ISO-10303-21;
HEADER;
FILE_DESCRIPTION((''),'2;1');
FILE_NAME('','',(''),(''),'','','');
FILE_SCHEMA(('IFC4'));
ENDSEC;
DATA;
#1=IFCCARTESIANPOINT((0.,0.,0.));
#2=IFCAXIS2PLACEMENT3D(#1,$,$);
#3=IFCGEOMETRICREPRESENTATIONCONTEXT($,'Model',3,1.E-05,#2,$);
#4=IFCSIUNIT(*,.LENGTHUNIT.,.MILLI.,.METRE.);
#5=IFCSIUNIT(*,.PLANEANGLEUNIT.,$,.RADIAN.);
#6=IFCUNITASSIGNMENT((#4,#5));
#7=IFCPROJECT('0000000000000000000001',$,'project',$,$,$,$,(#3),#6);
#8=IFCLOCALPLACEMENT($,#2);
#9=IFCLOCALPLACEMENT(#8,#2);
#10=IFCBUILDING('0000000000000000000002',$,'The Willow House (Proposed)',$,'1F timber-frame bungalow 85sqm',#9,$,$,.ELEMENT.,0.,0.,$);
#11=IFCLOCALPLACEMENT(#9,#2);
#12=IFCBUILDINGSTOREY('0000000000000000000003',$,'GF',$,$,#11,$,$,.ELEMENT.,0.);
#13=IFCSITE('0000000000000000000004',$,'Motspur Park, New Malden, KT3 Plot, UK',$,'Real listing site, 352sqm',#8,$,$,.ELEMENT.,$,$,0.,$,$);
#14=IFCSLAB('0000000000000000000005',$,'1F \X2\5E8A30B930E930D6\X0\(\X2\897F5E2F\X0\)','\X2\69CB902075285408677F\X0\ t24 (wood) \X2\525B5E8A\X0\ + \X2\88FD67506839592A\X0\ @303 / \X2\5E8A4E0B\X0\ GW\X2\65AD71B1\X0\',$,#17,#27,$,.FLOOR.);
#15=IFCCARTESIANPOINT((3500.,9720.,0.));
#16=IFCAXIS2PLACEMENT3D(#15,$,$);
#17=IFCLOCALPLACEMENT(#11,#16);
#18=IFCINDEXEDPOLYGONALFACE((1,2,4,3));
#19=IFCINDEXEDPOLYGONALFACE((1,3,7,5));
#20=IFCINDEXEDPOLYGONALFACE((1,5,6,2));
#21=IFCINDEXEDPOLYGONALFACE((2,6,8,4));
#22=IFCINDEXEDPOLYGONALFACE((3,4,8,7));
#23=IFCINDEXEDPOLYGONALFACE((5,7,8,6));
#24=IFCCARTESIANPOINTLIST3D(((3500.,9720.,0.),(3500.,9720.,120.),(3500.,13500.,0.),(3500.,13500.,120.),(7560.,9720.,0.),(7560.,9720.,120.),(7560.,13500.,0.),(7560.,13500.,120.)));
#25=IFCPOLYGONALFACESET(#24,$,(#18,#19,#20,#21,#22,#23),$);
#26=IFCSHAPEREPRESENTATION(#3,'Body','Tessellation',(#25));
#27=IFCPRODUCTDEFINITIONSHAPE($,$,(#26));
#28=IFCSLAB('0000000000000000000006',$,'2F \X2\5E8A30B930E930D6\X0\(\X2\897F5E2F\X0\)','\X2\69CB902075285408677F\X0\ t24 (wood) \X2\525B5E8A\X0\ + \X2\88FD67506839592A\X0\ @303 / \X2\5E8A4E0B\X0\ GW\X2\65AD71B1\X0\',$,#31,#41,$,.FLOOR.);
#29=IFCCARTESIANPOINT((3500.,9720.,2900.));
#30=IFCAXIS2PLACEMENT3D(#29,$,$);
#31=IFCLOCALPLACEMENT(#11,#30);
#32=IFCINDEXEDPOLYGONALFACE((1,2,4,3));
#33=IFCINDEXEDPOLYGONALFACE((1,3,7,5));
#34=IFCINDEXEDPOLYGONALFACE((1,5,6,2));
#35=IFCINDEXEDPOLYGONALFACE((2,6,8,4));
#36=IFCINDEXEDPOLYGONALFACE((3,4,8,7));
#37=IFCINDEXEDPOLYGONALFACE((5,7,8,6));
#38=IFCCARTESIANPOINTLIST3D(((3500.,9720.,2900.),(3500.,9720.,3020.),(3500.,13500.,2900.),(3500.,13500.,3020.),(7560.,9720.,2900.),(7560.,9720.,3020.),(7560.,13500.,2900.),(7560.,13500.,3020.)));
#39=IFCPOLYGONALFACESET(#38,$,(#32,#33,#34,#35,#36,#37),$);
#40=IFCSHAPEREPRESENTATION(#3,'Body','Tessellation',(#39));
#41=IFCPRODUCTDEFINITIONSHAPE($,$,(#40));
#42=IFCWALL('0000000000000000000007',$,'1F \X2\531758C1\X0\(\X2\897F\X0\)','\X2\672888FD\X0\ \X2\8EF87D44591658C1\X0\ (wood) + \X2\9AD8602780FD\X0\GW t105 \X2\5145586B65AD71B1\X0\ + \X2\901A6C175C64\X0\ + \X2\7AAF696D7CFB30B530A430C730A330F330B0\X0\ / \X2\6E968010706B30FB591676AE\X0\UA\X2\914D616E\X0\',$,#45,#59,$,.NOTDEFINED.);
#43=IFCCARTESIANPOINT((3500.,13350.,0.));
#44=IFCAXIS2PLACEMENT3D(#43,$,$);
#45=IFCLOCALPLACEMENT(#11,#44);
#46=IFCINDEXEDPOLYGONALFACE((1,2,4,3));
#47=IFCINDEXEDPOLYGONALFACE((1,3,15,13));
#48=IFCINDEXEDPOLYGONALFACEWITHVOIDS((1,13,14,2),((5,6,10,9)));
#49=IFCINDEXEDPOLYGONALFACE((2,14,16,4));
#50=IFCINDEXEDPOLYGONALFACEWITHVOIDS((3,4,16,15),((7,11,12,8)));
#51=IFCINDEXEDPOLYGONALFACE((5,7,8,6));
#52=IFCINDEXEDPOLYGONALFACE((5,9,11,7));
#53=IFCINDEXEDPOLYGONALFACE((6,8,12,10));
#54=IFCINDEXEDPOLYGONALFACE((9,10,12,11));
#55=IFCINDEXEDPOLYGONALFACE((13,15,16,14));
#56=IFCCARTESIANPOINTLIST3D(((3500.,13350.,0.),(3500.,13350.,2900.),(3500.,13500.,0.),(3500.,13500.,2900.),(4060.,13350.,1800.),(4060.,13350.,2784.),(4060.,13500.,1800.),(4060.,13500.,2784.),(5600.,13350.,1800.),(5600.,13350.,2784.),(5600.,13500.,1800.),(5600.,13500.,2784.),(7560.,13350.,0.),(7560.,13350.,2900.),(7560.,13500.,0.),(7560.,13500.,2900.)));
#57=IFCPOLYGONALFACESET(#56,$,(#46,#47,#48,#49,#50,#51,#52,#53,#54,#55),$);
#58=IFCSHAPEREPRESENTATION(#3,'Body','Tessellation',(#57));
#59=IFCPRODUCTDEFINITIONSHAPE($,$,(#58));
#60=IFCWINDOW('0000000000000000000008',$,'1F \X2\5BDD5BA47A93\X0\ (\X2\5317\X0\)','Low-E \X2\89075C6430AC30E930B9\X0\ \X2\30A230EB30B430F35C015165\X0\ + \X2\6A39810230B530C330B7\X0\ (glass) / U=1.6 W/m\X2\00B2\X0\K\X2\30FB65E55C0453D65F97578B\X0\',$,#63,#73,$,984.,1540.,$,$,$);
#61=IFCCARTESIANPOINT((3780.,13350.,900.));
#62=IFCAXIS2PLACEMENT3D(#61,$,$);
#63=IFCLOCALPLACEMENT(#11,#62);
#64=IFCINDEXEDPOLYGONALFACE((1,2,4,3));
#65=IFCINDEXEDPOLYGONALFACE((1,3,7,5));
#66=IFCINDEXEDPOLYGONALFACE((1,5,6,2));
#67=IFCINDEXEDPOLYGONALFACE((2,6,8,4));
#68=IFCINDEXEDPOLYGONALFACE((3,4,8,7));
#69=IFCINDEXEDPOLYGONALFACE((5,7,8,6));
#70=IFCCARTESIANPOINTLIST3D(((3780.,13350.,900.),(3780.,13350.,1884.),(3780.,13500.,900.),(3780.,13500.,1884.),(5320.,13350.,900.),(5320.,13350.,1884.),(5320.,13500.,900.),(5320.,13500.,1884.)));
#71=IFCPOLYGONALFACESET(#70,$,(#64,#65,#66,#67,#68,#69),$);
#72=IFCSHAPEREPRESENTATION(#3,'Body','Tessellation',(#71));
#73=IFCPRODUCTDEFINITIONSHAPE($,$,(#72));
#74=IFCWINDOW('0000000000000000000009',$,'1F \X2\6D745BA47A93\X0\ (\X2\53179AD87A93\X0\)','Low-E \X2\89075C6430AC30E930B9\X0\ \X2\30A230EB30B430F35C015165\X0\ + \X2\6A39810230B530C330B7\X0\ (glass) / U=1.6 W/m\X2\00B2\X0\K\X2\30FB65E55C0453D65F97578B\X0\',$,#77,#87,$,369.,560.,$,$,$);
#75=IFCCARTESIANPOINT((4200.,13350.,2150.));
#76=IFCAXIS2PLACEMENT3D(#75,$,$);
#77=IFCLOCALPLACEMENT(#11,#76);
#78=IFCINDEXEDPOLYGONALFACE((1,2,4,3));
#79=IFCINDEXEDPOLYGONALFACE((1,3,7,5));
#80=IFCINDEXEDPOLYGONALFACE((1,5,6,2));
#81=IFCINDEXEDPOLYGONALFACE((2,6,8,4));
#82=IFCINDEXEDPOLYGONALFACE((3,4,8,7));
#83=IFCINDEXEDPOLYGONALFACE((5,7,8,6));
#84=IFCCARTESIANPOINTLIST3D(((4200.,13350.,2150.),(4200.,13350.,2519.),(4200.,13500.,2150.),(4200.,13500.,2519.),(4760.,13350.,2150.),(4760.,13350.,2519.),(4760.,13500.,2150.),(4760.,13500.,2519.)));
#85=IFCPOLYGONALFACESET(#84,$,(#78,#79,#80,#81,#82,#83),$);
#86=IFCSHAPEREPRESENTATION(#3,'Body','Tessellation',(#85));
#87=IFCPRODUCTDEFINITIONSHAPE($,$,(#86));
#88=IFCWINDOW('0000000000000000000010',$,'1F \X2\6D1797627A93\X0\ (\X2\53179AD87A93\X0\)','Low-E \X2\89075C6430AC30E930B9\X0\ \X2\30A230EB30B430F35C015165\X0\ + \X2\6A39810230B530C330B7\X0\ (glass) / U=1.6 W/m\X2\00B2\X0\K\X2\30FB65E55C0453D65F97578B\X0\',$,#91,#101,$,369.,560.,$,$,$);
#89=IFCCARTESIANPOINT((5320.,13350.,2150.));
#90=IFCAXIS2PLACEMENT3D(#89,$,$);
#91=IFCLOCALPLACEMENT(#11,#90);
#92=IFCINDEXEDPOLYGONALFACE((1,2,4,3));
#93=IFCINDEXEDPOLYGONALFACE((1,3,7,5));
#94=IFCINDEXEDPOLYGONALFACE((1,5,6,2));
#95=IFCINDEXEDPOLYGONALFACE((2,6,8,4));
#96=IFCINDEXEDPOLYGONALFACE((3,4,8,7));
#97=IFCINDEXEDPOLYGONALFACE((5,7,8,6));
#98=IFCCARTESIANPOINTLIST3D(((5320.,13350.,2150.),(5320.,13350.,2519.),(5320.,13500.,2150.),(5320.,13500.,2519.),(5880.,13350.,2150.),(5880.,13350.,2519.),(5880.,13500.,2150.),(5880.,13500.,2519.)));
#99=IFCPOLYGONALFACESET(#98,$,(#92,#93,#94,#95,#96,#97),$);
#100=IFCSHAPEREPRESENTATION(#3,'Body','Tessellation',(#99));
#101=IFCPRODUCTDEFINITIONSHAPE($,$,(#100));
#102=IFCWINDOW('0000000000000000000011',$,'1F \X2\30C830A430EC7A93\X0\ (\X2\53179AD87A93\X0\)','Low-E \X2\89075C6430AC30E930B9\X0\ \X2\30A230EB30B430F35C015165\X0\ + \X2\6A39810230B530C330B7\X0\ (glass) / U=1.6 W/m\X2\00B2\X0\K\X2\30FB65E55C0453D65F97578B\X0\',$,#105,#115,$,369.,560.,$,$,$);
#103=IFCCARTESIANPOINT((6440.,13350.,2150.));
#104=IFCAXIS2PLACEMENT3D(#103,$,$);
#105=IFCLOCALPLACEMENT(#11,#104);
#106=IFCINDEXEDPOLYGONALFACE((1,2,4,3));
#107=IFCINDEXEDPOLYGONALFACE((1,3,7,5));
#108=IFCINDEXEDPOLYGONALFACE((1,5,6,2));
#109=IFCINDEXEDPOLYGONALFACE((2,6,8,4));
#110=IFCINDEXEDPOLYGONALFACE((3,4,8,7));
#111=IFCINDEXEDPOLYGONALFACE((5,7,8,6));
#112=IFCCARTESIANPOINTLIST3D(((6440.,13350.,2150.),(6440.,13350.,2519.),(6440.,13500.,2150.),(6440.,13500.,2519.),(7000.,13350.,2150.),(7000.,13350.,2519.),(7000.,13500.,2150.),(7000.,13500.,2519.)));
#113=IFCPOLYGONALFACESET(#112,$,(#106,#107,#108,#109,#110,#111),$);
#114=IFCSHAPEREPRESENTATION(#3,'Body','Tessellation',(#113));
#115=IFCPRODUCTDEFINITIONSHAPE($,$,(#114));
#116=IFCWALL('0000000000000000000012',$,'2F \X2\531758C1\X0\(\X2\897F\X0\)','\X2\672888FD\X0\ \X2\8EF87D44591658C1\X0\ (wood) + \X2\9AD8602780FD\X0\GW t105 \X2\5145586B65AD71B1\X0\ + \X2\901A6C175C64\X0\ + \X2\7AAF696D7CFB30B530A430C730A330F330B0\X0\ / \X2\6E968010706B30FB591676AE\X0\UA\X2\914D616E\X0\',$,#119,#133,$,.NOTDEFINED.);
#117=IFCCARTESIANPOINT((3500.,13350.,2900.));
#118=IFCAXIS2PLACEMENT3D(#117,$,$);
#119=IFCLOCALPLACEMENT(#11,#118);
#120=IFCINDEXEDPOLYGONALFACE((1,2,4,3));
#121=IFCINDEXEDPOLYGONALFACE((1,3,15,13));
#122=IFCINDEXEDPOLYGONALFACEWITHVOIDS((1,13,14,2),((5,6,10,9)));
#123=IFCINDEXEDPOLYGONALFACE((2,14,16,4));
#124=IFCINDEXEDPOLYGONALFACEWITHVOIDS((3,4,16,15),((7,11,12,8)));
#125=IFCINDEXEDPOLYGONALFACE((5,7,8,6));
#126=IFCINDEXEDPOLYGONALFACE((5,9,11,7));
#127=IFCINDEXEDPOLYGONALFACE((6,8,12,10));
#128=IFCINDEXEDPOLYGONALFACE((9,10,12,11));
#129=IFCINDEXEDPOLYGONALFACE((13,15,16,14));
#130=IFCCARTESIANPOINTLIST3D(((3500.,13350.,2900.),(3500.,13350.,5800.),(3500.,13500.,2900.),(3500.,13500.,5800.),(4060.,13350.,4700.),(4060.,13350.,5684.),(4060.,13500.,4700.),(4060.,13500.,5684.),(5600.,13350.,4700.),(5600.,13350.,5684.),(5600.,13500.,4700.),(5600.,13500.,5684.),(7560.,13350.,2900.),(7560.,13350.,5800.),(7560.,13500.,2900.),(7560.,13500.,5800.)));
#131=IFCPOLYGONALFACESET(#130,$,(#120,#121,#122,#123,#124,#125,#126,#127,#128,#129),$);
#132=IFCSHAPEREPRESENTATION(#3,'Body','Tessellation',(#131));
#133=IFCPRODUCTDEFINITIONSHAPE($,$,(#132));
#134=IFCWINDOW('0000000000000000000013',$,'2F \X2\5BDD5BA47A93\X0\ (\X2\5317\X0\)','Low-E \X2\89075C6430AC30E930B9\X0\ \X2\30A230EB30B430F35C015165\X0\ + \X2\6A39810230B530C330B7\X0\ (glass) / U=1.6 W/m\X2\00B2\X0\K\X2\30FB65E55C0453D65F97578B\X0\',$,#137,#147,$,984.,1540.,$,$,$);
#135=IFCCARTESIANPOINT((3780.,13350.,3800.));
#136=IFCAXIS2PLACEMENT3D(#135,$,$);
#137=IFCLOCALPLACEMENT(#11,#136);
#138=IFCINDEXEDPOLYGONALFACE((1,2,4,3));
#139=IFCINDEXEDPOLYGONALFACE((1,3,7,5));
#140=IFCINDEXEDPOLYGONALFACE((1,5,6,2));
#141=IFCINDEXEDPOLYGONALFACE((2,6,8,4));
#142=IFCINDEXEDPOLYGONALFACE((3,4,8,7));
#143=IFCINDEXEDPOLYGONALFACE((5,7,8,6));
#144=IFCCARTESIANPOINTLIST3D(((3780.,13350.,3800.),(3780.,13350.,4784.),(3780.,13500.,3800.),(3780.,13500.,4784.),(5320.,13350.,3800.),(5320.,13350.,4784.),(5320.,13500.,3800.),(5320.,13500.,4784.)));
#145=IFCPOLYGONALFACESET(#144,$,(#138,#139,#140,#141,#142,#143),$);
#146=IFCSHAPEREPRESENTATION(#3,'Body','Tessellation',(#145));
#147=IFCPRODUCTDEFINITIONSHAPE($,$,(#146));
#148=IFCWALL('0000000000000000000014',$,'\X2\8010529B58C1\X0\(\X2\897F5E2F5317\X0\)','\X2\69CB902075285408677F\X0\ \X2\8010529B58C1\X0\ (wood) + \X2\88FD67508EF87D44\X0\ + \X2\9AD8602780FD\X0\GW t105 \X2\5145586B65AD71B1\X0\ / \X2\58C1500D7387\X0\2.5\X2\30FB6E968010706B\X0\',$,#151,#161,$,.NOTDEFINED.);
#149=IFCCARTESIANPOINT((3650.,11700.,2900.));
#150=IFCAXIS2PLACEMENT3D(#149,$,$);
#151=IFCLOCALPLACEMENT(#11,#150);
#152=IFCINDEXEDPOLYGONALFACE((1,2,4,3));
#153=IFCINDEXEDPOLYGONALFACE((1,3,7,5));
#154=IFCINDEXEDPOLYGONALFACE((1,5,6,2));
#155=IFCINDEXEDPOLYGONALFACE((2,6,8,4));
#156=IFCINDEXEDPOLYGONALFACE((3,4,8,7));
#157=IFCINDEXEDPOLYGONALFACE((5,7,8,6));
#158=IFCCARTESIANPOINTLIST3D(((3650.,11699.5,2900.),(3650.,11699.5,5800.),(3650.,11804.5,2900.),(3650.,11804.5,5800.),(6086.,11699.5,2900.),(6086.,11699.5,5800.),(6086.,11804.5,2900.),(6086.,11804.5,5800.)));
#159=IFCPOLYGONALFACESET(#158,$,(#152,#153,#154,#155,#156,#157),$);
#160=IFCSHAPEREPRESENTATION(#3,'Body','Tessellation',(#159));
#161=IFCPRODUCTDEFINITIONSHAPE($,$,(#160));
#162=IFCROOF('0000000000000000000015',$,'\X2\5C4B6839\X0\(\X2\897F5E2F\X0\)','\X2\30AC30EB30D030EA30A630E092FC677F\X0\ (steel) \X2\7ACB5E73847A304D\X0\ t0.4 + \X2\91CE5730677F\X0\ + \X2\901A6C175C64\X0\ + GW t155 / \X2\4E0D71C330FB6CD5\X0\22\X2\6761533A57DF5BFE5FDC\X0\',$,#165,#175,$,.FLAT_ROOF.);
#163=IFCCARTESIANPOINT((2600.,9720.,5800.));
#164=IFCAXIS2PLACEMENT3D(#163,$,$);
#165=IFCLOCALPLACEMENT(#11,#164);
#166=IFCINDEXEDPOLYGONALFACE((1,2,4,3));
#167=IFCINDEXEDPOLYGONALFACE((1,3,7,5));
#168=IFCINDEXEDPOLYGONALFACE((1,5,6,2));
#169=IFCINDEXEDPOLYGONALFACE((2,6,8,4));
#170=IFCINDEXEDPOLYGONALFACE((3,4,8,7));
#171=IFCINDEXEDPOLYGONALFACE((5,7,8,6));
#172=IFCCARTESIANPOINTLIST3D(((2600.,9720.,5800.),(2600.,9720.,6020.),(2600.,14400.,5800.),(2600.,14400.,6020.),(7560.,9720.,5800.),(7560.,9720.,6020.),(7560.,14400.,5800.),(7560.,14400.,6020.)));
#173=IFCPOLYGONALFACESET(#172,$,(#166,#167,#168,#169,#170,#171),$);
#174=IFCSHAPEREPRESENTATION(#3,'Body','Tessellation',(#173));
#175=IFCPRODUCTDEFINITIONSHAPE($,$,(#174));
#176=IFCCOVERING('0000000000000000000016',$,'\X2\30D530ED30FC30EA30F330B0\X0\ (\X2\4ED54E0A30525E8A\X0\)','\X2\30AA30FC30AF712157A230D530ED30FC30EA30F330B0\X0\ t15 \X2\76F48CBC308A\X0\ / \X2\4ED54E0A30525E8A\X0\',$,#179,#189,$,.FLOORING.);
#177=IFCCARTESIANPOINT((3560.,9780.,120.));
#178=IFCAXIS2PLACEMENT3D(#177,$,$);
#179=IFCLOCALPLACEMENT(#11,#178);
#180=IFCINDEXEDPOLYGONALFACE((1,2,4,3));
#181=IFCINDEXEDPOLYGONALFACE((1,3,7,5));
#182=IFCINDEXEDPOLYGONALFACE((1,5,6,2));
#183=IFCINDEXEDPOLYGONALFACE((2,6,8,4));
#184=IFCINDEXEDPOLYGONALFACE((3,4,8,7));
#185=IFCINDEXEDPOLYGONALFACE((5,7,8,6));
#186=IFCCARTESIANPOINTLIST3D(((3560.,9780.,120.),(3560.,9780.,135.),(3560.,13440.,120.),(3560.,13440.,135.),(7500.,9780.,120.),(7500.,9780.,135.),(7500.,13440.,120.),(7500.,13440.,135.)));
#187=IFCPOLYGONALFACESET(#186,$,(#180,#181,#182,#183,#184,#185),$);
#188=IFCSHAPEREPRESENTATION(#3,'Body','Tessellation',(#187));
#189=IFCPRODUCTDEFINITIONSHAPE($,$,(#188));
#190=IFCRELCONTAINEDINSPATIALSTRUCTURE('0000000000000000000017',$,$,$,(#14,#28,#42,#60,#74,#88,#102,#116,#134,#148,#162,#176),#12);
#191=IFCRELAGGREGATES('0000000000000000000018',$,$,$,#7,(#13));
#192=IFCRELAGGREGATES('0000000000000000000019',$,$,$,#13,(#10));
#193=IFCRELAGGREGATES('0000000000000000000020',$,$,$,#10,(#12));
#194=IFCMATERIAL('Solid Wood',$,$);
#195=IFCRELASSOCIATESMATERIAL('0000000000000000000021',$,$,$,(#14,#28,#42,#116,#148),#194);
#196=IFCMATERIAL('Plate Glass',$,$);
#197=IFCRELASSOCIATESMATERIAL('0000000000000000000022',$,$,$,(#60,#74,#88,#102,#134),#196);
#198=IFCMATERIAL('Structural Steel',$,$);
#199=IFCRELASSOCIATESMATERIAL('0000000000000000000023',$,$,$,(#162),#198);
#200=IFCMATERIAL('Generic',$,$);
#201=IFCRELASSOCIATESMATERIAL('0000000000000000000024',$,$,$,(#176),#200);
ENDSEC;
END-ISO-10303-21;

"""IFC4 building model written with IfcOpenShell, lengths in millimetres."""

from ifc_helpers import new_model, si_unit, frame, frame_2d, origin, place, context, project, spatial, rectangle, extrude, material, element, fill, save


model = new_model("IFC4")

# Units and contexts
model_context = context("Model", 3, precision=1e-05, world=origin())
ifc_project = project(units=[si_unit("LENGTHUNIT", "METRE", prefix="MILLI"), si_unit("PLANEANGLEUNIT", "RADIAN")], contexts=[model_context])

# Site, building, storey
site_placement = place(None, origin())
site = spatial("IfcSite", under=ifc_project, at=site_placement, Name="Motspur Park, New Malden, KT3 Plot, UK", ObjectType="Real listing site, 352sqm", CompositionType="ELEMENT", RefElevation=0.0)
building_placement = place(site_placement, origin())
building = spatial("IfcBuilding", under=site, at=building_placement, Name="The Willow House (Proposed)", ObjectType="1F timber-frame bungalow 85sqm", CompositionType="ELEMENT", ElevationOfRefHeight=0.0, ElevationOfTerrain=0.0)
storey_placement = place(building_placement, origin())
storey = spatial("IfcBuildingStorey", under=building, at=storey_placement, Name="GF", CompositionType="ELEMENT", Elevation=0.0)

# Slabs
ifc_material_1 = material(Name="Solid Wood")
slab_1_placement = place(storey_placement, frame((3500.0, 9720.0, 0.0)))
element("IfcSlab", 1, at=slab_1_placement, inside=storey, material=ifc_material_1, Name="1F 床スラブ(西帯)", Description="構造用合板 t24 (wood) 剛床 + 製材根太 @303 / 床下 GW断熱", PredefinedType="FLOOR", context=model_context, shape_type="SweptSolid", body=[
    extrude(rectangle(XDim=4060.0, YDim=3780.0, at=frame_2d((2030.0, 1890.0))), frame((3500.0, 9720.0, 0.0)), (0.0, 0.0, 1.0), 120.0),
])
slab_2_placement = place(storey_placement, frame((3500.0, 9720.0, 2900.0)))
element("IfcSlab", 2, at=slab_2_placement, inside=storey, material=ifc_material_1, Name="2F 床スラブ(西帯)", Description="構造用合板 t24 (wood) 剛床 + 製材根太 @303 / 床下 GW断熱", PredefinedType="FLOOR", context=model_context, shape_type="SweptSolid", body=[
    extrude(rectangle(XDim=4060.0, YDim=3780.0, at=frame_2d((2030.0, 1890.0))), frame((3500.0, 9720.0, 2900.0)), (0.0, 0.0, 1.0), 120.0),
])

# Wall, openings, windows
wall_1_placement = place(storey_placement, frame((3500.0, 13350.0, 0.0)))
wall_1 = element("IfcWall", 3, at=wall_1_placement, inside=storey, material=ifc_material_1, Name="1F 北壁(西)", Description="木製 軸組外壁 (wood) + 高性能GW t105 充填断熱 + 通気層 + 窯業系サイディング / 準耐火・外皮UA配慮", PredefinedType="NOTDEFINED", context=model_context, shape_type="SweptSolid", body=[
    extrude(rectangle(XDim=4060.0, YDim=150.0, at=frame_2d((2030.0, 75.0))), frame((3500.0, 13350.0, 0.0)), (0.0, 0.0, 1.0), 2900.0),
])
opening_1_placement = place(storey_placement, frame((3780.0, 13350.0, 900.0)))
opening_1 = element("IfcOpeningElement", 4, at=opening_1_placement, cuts=wall_1, PredefinedType="NOTDEFINED", context=model_context, shape_type="SweptSolid", body=[
    extrude(rectangle(XDim=1540.0, YDim=150.0, at=frame_2d((770.0, 75.0))), frame((3780.0, 13350.0, 900.0)), (0.0, 0.0, 1.0), 984.0),
])
opening_2_placement = place(storey_placement, frame((4200.0, 13350.0, 2150.0)))
opening_2 = element("IfcOpeningElement", 5, at=opening_2_placement, cuts=wall_1, PredefinedType="NOTDEFINED", context=model_context, shape_type="SweptSolid", body=[
    extrude(rectangle(XDim=560.0, YDim=150.0, at=frame_2d((280.0, 75.0))), frame((4200.0, 13350.0, 2150.0)), (0.0, 0.0, 1.0), 369.0),
])
opening_3_placement = place(storey_placement, frame((5320.0, 13350.0, 2150.0)))
opening_3 = element("IfcOpeningElement", 6, at=opening_3_placement, cuts=wall_1, PredefinedType="NOTDEFINED", context=model_context, shape_type="SweptSolid", body=[
    extrude(rectangle(XDim=560.0, YDim=150.0, at=frame_2d((280.0, 75.0))), frame((5320.0, 13350.0, 2150.0)), (0.0, 0.0, 1.0), 369.0),
])
opening_4_placement = place(storey_placement, frame((6440.0, 13350.0, 2150.0)))
opening_4 = element("IfcOpeningElement", 7, at=opening_4_placement, cuts=wall_1, PredefinedType="NOTDEFINED", context=model_context, shape_type="SweptSolid", body=[
    extrude(rectangle(XDim=560.0, YDim=150.0, at=frame_2d((280.0, 75.0))), frame((6440.0, 13350.0, 2150.0)), (0.0, 0.0, 1.0), 369.0),
])
ifc_material_2 = material(Name="Plate Glass")
window_1_placement = place(storey_placement, frame((3780.0, 13350.0, 900.0)))
window_1 = element("IfcWindow", 8, at=window_1_placement, inside=storey, material=ifc_material_2, Name="1F 寝室窓 (北)", Description="Low-E 複層ガラス アルゴン封入 + 樹脂サッシ (glass) / U=1.6 W/m²K・日射取得型", OverallHeight=984.0, OverallWidth=1540.0, context=model_context, shape_type="SweptSolid", body=[
    extrude(rectangle(XDim=1540.0, YDim=150.0, at=frame_2d((770.0, 75.0))), frame((3780.0, 13350.0, 900.0)), (0.0, 0.0, 1.0), 984.0),
])
fill(opening_1, window_1)
window_2_placement = place(storey_placement, frame((4200.0, 13350.0, 2150.0)))
window_2 = element("IfcWindow", 9, at=window_2_placement, inside=storey, material=ifc_material_2, Name="1F 浴室窓 (北高窓)", Description="Low-E 複層ガラス アルゴン封入 + 樹脂サッシ (glass) / U=1.6 W/m²K・日射取得型", OverallHeight=369.0, OverallWidth=560.0, context=model_context, shape_type="SweptSolid", body=[
    extrude(rectangle(XDim=560.0, YDim=150.0, at=frame_2d((280.0, 75.0))), frame((4200.0, 13350.0, 2150.0)), (0.0, 0.0, 1.0), 369.0),
])
fill(opening_2, window_2)
window_3_placement = place(storey_placement, frame((5320.0, 13350.0, 2150.0)))
window_3 = element("IfcWindow", 10, at=window_3_placement, inside=storey, material=ifc_material_2, Name="1F 洗面窓 (北高窓)", Description="Low-E 複層ガラス アルゴン封入 + 樹脂サッシ (glass) / U=1.6 W/m²K・日射取得型", OverallHeight=369.0, OverallWidth=560.0, context=model_context, shape_type="SweptSolid", body=[
    extrude(rectangle(XDim=560.0, YDim=150.0, at=frame_2d((280.0, 75.0))), frame((5320.0, 13350.0, 2150.0)), (0.0, 0.0, 1.0), 369.0),
])
fill(opening_3, window_3)
window_4_placement = place(storey_placement, frame((6440.0, 13350.0, 2150.0)))
window_4 = element("IfcWindow", 11, at=window_4_placement, inside=storey, material=ifc_material_2, Name="1F トイレ窓 (北高窓)", Description="Low-E 複層ガラス アルゴン封入 + 樹脂サッシ (glass) / U=1.6 W/m²K・日射取得型", OverallHeight=369.0, OverallWidth=560.0, context=model_context, shape_type="SweptSolid", body=[
    extrude(rectangle(XDim=560.0, YDim=150.0, at=frame_2d((280.0, 75.0))), frame((6440.0, 13350.0, 2150.0)), (0.0, 0.0, 1.0), 369.0),
])
fill(opening_4, window_4)

# Wall, opening, window
wall_2_placement = place(storey_placement, frame((3500.0, 13350.0, 2900.0)))
wall_2 = element("IfcWall", 12, at=wall_2_placement, inside=storey, material=ifc_material_1, Name="2F 北壁(西)", Description="木製 軸組外壁 (wood) + 高性能GW t105 充填断熱 + 通気層 + 窯業系サイディング / 準耐火・外皮UA配慮", PredefinedType="NOTDEFINED", context=model_context, shape_type="SweptSolid", body=[
    extrude(rectangle(XDim=4060.0, YDim=150.0, at=frame_2d((2030.0, 75.0))), frame((3500.0, 13350.0, 2900.0)), (0.0, 0.0, 1.0), 2900.0),
])
opening_5_placement = place(storey_placement, frame((3780.0, 13350.0, 3800.0)))
opening_5 = element("IfcOpeningElement", 13, at=opening_5_placement, cuts=wall_2, PredefinedType="NOTDEFINED", context=model_context, shape_type="SweptSolid", body=[
    extrude(rectangle(XDim=1540.0, YDim=150.0, at=frame_2d((770.0, 75.0))), frame((3780.0, 13350.0, 3800.0)), (0.0, 0.0, 1.0), 984.0),
])
window_5_placement = place(storey_placement, frame((3780.0, 13350.0, 3800.0)))
window_5 = element("IfcWindow", 14, at=window_5_placement, inside=storey, material=ifc_material_2, Name="2F 寝室窓 (北)", Description="Low-E 複層ガラス アルゴン封入 + 樹脂サッシ (glass) / U=1.6 W/m²K・日射取得型", OverallHeight=984.0, OverallWidth=1540.0, context=model_context, shape_type="SweptSolid", body=[
    extrude(rectangle(XDim=1540.0, YDim=150.0, at=frame_2d((770.0, 75.0))), frame((3780.0, 13350.0, 3800.0)), (0.0, 0.0, 1.0), 984.0),
])
fill(opening_5, window_5)

# Wall
wall_3_placement = place(storey_placement, frame((3650.0, 11700.0, 2900.0)))
element("IfcWall", 15, at=wall_3_placement, inside=storey, material=ifc_material_1, Name="耐力壁(西帯北)", Description="構造用合板 耐力壁 (wood) + 製材軸組 + 高性能GW t105 充填断熱 / 壁倍率2.5・準耐火", PredefinedType="NOTDEFINED", context=model_context, shape_type="SweptSolid", body=[
    extrude(rectangle(XDim=2436.0, YDim=105.0, at=frame_2d((1218.0, 52.0))), frame((3650.0, 11700.0, 2900.0)), (0.0, 0.0, 1.0), 2900.0),
])

# Roof
ifc_material_3 = material(Name="Structural Steel")
for number, where, name in (
    (16, (2600.0, 9720.0, 5800.0), "屋根(西帯)"),
):
    element("IfcRoof", number, at=place(storey_placement, frame(where)), inside=storey, material=ifc_material_3, Name=name, Description="ガルバリウム鋼板 (steel) 立平葺き t0.4 + 野地板 + 通気層 + GW t155 / 不燃・法22条区域対応", PredefinedType="FLAT_ROOF", context=model_context, shape_type="SweptSolid", body=[
        extrude(rectangle(XDim=4960.0, YDim=4680.0, at=frame_2d((2480.0, 2340.0))), frame((2600.0, 9720.0, 5800.0)), (0.0, 0.0, 1.0), 220.0),
    ])

# Covering
ifc_material_4 = material(Name="Generic")
covering_1_placement = place(storey_placement, frame((3560.0, 9780.0, 120.0)))
element("IfcCovering", 17, at=covering_1_placement, inside=storey, material=ifc_material_4, Name="フローリング (仕上げ床)", Description="オーク無垢フローリング t15 直貼り / 仕上げ床", PredefinedType="FLOORING", context=model_context, shape_type="SweptSolid", body=[
    extrude(rectangle(XDim=3940.0, YDim=3660.0, at=frame_2d((1970.0, 1830.0))), frame((3560.0, 9780.0, 120.0)), (0.0, 0.0, 1.0), 15.0),
])

save(model, "model.ifc")
